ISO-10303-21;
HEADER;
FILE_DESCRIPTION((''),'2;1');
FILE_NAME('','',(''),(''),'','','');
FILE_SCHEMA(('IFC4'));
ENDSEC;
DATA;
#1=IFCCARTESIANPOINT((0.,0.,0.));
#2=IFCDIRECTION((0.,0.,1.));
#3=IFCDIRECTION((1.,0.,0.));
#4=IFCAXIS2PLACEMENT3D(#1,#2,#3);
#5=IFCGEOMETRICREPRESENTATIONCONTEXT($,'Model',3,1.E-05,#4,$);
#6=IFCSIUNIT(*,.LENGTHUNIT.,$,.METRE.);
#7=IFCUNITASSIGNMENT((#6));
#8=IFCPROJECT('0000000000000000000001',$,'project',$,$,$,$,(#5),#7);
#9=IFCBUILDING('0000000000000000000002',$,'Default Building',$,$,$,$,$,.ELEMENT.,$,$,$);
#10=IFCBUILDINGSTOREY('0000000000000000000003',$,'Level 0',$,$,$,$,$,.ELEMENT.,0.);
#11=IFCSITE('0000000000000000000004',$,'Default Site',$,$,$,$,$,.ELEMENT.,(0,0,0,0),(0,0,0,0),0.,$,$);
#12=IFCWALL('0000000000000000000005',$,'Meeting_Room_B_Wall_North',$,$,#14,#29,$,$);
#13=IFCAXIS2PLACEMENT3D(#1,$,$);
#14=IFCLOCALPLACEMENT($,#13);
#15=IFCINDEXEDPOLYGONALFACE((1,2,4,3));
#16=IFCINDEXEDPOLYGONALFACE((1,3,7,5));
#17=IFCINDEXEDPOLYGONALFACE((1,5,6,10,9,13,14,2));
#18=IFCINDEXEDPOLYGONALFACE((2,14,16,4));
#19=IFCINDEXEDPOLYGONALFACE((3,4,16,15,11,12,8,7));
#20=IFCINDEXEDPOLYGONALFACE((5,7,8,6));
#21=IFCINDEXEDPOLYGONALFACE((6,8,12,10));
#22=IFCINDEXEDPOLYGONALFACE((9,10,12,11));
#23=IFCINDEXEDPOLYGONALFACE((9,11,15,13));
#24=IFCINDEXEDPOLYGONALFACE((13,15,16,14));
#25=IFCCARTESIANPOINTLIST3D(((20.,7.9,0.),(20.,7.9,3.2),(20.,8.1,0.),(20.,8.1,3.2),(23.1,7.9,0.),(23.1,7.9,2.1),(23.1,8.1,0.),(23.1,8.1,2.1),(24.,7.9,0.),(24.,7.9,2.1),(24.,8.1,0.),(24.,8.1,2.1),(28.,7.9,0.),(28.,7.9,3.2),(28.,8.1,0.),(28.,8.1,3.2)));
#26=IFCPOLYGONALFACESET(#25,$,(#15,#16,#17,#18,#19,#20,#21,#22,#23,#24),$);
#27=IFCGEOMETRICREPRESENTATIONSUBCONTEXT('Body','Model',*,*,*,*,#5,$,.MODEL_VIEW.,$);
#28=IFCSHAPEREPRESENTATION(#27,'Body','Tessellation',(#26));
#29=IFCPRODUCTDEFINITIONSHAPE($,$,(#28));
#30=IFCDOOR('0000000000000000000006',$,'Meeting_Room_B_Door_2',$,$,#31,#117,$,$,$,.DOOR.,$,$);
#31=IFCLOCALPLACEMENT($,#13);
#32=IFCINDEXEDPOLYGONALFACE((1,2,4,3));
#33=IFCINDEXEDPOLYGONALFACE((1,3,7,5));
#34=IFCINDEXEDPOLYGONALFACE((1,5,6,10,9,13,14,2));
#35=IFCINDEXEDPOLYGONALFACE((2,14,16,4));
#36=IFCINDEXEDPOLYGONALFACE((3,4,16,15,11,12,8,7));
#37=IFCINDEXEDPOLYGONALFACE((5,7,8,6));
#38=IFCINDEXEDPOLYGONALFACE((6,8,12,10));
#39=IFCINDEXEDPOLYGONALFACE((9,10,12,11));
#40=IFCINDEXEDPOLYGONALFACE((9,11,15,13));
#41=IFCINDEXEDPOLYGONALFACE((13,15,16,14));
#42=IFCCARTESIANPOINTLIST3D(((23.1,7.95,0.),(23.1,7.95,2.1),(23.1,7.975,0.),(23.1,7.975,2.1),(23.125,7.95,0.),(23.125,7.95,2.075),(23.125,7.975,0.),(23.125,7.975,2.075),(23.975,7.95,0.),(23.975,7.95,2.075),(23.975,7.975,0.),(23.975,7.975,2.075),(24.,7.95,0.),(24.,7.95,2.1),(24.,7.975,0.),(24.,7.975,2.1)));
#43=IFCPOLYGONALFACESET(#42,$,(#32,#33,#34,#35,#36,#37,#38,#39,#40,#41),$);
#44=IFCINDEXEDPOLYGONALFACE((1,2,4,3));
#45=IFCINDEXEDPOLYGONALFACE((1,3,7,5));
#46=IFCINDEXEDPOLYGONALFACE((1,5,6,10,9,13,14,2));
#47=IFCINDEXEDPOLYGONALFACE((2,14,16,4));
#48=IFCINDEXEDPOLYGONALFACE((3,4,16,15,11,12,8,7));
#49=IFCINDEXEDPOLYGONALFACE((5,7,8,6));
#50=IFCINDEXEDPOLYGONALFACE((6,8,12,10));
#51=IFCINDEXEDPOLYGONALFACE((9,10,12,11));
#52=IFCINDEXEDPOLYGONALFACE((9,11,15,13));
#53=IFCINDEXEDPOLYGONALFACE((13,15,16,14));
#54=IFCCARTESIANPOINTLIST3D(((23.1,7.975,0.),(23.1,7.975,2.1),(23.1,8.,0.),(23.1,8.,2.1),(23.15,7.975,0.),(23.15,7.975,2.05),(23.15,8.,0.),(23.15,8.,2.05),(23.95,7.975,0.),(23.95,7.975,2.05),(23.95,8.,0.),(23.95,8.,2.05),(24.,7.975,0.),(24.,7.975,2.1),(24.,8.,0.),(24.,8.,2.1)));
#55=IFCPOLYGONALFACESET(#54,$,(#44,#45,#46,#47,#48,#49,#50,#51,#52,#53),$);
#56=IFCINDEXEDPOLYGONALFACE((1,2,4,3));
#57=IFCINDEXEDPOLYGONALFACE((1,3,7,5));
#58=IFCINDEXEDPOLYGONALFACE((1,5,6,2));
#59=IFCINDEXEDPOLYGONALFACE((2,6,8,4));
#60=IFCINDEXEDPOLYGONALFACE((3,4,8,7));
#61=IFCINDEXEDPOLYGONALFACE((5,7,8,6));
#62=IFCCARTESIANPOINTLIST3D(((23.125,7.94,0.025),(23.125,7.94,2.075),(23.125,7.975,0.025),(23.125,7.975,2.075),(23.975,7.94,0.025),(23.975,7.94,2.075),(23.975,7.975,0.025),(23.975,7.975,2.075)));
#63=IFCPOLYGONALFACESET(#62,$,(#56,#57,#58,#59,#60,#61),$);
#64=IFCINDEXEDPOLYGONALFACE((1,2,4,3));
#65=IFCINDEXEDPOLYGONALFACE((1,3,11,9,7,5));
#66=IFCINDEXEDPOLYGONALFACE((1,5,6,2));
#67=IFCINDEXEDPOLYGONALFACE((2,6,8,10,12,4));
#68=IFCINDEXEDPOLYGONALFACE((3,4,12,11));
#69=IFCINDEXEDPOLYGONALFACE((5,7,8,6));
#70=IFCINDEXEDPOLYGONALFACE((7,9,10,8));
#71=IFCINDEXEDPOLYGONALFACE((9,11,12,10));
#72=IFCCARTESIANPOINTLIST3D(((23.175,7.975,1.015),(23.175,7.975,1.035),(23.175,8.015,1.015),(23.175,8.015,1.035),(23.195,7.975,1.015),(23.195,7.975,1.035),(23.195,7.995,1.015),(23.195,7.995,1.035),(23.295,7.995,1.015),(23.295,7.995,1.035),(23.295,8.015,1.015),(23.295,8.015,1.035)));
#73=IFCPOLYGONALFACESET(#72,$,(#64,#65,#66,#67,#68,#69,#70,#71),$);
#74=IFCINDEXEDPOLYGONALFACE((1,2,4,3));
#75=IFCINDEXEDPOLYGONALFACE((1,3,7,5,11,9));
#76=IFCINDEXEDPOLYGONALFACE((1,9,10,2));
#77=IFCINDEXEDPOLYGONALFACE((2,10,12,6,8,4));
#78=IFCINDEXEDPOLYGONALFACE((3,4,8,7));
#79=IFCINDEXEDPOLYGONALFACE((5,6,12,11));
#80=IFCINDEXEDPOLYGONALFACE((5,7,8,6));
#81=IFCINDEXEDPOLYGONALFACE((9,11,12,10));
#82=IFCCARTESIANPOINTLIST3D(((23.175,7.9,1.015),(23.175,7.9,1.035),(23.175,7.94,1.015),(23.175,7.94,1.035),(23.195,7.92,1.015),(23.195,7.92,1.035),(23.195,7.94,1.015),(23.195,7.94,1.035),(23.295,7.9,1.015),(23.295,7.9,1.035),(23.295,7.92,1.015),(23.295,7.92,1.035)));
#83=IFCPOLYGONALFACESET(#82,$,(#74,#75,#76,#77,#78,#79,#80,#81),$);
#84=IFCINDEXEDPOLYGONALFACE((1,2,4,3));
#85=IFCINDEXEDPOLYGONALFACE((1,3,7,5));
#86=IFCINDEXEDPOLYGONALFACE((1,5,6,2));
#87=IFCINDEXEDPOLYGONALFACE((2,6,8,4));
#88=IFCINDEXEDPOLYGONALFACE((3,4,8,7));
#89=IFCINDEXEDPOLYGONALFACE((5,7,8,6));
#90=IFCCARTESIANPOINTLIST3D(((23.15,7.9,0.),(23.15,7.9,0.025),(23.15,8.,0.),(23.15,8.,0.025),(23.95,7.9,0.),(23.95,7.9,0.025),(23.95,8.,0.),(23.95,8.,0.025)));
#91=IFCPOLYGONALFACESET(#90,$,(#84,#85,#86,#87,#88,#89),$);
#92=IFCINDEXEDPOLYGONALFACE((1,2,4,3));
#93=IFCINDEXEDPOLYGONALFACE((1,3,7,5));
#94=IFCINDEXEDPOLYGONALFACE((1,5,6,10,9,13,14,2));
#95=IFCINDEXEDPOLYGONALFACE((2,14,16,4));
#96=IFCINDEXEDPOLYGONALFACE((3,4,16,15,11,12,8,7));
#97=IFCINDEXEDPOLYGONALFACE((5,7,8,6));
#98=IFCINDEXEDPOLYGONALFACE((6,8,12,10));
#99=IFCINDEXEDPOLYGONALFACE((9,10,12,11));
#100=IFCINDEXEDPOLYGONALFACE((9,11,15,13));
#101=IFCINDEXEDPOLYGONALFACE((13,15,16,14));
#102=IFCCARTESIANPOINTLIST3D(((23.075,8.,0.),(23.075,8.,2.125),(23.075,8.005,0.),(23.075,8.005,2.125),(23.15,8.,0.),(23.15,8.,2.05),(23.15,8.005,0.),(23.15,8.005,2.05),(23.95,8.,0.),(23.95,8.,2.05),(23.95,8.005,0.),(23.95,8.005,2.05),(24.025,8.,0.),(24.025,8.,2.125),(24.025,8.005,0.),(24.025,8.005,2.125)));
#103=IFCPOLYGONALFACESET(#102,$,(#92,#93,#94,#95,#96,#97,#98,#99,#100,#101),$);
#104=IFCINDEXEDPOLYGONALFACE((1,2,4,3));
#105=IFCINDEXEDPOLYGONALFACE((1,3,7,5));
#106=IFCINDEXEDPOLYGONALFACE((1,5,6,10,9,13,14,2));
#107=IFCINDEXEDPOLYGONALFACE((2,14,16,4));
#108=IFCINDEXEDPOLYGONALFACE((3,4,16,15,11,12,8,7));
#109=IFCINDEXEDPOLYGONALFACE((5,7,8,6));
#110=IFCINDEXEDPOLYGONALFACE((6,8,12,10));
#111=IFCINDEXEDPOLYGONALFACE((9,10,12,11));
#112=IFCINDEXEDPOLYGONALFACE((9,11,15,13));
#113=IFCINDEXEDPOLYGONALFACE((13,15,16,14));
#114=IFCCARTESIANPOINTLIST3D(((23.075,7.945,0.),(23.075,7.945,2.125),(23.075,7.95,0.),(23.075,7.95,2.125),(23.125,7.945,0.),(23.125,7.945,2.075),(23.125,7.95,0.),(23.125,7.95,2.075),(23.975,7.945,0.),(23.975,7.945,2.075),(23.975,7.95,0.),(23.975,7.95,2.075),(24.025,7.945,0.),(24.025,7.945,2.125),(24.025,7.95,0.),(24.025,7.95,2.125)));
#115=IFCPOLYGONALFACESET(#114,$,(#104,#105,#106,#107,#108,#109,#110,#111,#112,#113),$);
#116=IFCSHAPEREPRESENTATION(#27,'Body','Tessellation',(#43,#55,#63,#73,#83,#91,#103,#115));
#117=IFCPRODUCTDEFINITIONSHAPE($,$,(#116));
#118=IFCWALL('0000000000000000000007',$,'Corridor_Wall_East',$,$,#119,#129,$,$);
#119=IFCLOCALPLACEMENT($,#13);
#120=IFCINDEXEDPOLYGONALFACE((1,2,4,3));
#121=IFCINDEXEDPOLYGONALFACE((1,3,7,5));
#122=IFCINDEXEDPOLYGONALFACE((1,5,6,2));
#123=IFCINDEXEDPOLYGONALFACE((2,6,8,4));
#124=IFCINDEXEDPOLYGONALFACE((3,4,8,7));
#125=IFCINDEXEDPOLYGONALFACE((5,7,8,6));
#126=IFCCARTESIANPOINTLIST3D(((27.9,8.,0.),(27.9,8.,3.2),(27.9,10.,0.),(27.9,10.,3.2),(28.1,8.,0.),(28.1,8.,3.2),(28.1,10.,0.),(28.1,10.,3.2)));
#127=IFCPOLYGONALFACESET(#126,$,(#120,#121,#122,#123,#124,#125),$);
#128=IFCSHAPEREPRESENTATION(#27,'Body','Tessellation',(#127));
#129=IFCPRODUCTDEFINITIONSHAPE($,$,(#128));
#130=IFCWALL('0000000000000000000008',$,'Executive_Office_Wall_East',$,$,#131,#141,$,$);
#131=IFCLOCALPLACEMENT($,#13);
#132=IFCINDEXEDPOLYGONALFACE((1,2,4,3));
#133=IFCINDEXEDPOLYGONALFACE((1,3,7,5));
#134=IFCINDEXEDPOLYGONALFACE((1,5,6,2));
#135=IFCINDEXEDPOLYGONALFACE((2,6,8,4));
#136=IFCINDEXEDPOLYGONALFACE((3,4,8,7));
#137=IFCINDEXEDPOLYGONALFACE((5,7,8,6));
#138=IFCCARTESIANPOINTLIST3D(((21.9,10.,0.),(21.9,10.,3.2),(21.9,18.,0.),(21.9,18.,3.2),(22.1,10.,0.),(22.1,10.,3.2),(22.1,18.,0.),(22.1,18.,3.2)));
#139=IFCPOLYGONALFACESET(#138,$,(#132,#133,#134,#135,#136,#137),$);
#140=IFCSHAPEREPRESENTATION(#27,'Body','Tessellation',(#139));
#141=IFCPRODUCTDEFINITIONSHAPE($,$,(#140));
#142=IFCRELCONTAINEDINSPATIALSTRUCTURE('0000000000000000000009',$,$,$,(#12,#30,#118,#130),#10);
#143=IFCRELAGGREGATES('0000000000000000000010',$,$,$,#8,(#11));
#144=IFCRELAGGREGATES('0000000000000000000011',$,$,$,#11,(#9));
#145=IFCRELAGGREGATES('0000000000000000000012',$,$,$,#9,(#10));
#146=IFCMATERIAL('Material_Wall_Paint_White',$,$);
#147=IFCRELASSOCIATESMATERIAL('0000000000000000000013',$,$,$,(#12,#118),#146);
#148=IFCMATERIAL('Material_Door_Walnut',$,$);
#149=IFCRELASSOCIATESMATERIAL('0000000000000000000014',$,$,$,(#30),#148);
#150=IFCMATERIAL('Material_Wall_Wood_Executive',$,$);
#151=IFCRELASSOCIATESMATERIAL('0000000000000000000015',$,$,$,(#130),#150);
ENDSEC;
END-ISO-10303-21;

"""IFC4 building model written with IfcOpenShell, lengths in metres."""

from ifc_helpers import new_model, si_unit, frame, origin_with_axes, place, context, subcontext, project, spatial, line, indexed_curve, outline, extrude, material, element, fill, save


model = new_model("IFC4")

# Units and contexts
model_context = context("Model", 3, precision=1e-05, world=origin_with_axes())
body_context = subcontext(model_context, "Body", "Model", "MODEL_VIEW")
ifc_project = project(units=[si_unit("LENGTHUNIT", "METRE")], contexts=[model_context])

# Site, building, storey
site = spatial("IfcSite", under=ifc_project, Name="Default Site", CompositionType="ELEMENT", RefLatitude=(0, 0, 0, 0), RefLongitude=(0, 0, 0, 0), RefElevation=0.0)
building = spatial("IfcBuilding", under=site, Name="Default Building", CompositionType="ELEMENT")
storey = spatial("IfcBuildingStorey", under=building, Name="Level 0", CompositionType="ELEMENT", Elevation=0.0)

# Shared definitions
ifc_material_1 = material(Name="Material_Wall_Paint_White")

# Shared definitions
ifc_material_2 = material(Name="Material_Door_Walnut")

# Wall, opening, door
wall_1_placement = place(None, frame((28.0, 8.0, 0.0), z_axis=(0.0, 0.0, 1.0), x_axis=(-1.0, 0.0, 0.0)))
wall_1 = element("IfcWall", 1, at=wall_1_placement, inside=storey, material=ifc_material_1, Name="Meeting_Room_B_Wall_North", context=body_context, shape_type="SweptSolid", body=[
    extrude(outline(indexed_curve([(0.0, 0.0), (0.0, 0.2), (8.0, 0.2), (8.0, 0.0), (0.0, 0.0)], self_intersect=False)), frame((0.0, -0.1, 0.0), z_axis=(0.0, 0.0, 1.0), x_axis=(1.0, 0.0, 0.0)), (0.0, 0.0, 1.0), 3.2),
])
opening_1_placement = place(wall_1_placement, frame((4.0, -0.5, 0.0), z_axis=(0.0, 0.0, 1.0), x_axis=(1.0, 0.0, 0.0)))
opening_1 = element("IfcOpeningElement", 2, at=opening_1_placement, inside=storey, cuts=wall_1, PredefinedType="OPENING", context=body_context, shape_type="SweptSolid", body=[
    extrude(outline(indexed_curve([(0.0, 0.0), (0.0, 1.0), (0.9, 1.0), (0.9, 0.0), (0.0, 0.0)], self_intersect=False)), origin_with_axes(), (0.0, 0.0, 1.0), 2.1),
])
door_1_placement = place(None, frame((24.0, 8.0, 0.0), z_axis=(0.0, 0.0, 1.0), x_axis=(-1.0, 0.0, 0.0)))
door_1 = element("IfcDoor", 3, at=door_1_placement, inside=storey, material=ifc_material_2, Name="Meeting_Room_B_Door_2", PredefinedType="DOOR", context=body_context, shape_type="SweptSolid", body=[
    extrude(outline(indexed_curve([(0.0, 0.0), (0.0, 2.1), (0.9, 2.1), (0.9, 0.0), (0.875, 0.0), (0.875, 2.075), (0.025, 2.075), (0.025, 0.0)], segments=[line(1, 2, 3, 4, 5, 6, 7, 8, 1)])), frame((0.0, 0.025, 0.0), z_axis=(0.0, -1.0, 0.0), x_axis=(1.0, 0.0, 0.0)), (0.0, 0.0, -1.0), 0.025),
    extrude(outline(indexed_curve([(0.0, 0.0), (0.0, 2.1), (0.9, 2.1), (0.9, 0.0), (0.85, 0.0), (0.85, 2.05), (0.05, 2.05), (0.05, 0.0)], segments=[line(1, 2, 3, 4, 5, 6, 7, 8, 1)])), frame((0.0, 0.0, 0.0), z_axis=(0.0, -1.0, 0.0), x_axis=(1.0, 0.0, 0.0)), (0.0, 0.0, -1.0), 0.025),
    extrude(outline(indexed_curve([(0.0, 0.0), (0.85, 0.0), (0.85, 0.035), (0.0, 0.035)], segments=[line(1, 2, 3, 4, 1)])), frame((0.025, 0.025, 0.025), z_axis=(0.0, 0.0, 1.0), x_axis=(1.0, 0.0, 0.0)), (0.0, 0.0, 1.0), 2.05),
    extrude(outline(indexed_curve([(0.0, 0.0), (0.0, -0.04), (-0.12, -0.04), (-0.12, -0.02), (-0.02, -0.02), (-0.02, 0.0)], segments=[line(1, 2, 3, 4, 5, 6, 1)])), frame((0.825, 0.025, 1.015), z_axis=(0.0, 0.0, 1.0), x_axis=(1.0, 0.0, 0.0)), (0.0, 0.0, 1.0), 0.02),
    extrude(outline(indexed_curve([(0.0, 0.0), (0.0, 0.04), (-0.12, 0.04), (-0.12, 0.02), (-0.02, 0.02), (-0.02, 0.0)], segments=[line(1, 2, 3, 4, 5, 6, 1)])), frame((0.825, 0.06, 1.015), z_axis=(0.0, 0.0, 1.0), x_axis=(1.0, 0.0, 0.0)), (0.0, 0.0, 1.0), 0.02),
    extrude(outline(indexed_curve([(0.0, 0.0), (0.8, 0.0), (0.8, 0.1), (0.0, 0.1)], segments=[line(1, 2, 3, 4, 1)])), frame((0.05, 0.0, 0.0), z_axis=(0.0, 0.0, 1.0), x_axis=(1.0, 0.0, 0.0)), (0.0, 0.0, 1.0), 0.025),
    extrude(outline(indexed_curve([(0.0, 0.0), (0.0, 2.125), (0.95, 2.125), (0.95, 0.0), (0.875, 0.0), (0.875, 2.05), (0.075, 2.05), (0.075, 0.0)], segments=[line(1, 2, 3, 4, 5, 6, 7, 8, 1)])), frame((-0.025, -0.005, 0.0), z_axis=(0.0, -1.0, 0.0), x_axis=(1.0, 0.0, 0.0)), (0.0, 0.0, -1.0), 0.005),
    extrude(outline(indexed_curve([(0.0, 0.0), (0.0, 2.125), (0.95, 2.125), (0.95, 0.0), (0.9, 0.0), (0.9, 2.075), (0.05, 2.075), (0.05, 0.0)], segments=[line(1, 2, 3, 4, 5, 6, 7, 8, 1)])), frame((-0.025, 0.05, 0.0), z_axis=(0.0, -1.0, 0.0), x_axis=(1.0, 0.0, 0.0)), (0.0, 0.0, -1.0), 0.005),
])
fill(opening_1, door_1)

# Wall
wall_2_placement = place(None, frame((28.0, 8.0, 0.0), z_axis=(0.0, 0.0, 1.0), x_axis=(0.0, 1.0, 0.0)))
element("IfcWall", 4, at=wall_2_placement, inside=storey, material=ifc_material_1, Name="Corridor_Wall_East", context=body_context, shape_type="SweptSolid", body=[
    extrude(outline(indexed_curve([(0.0, 0.0), (0.0, 0.2), (2.0, 0.2), (2.0, 0.0), (0.0, 0.0)], self_intersect=False)), frame((0.0, -0.1, 0.0), z_axis=(0.0, 0.0, 1.0), x_axis=(1.0, 0.0, 0.0)), (0.0, 0.0, 1.0), 3.2),
])

# Wall
ifc_material_3 = material(Name="Material_Wall_Wood_Executive")
wall_3_placement = place(None, frame((22.0, 10.0, 0.0), z_axis=(0.0, 0.0, 1.0), x_axis=(0.0, 1.0, 0.0)))
element("IfcWall", 5, at=wall_3_placement, inside=storey, material=ifc_material_3, Name="Executive_Office_Wall_East", context=body_context, shape_type="SweptSolid", body=[
    extrude(outline(indexed_curve([(0.0, 0.0), (0.0, 0.2), (8.0, 0.2), (8.0, 0.0), (0.0, 0.0)], self_intersect=False)), frame((0.0, -0.1, 0.0), z_axis=(0.0, 0.0, 1.0), x_axis=(1.0, 0.0, 0.0)), (0.0, 0.0, 1.0), 3.2),
])

save(model, "model.ifc")
